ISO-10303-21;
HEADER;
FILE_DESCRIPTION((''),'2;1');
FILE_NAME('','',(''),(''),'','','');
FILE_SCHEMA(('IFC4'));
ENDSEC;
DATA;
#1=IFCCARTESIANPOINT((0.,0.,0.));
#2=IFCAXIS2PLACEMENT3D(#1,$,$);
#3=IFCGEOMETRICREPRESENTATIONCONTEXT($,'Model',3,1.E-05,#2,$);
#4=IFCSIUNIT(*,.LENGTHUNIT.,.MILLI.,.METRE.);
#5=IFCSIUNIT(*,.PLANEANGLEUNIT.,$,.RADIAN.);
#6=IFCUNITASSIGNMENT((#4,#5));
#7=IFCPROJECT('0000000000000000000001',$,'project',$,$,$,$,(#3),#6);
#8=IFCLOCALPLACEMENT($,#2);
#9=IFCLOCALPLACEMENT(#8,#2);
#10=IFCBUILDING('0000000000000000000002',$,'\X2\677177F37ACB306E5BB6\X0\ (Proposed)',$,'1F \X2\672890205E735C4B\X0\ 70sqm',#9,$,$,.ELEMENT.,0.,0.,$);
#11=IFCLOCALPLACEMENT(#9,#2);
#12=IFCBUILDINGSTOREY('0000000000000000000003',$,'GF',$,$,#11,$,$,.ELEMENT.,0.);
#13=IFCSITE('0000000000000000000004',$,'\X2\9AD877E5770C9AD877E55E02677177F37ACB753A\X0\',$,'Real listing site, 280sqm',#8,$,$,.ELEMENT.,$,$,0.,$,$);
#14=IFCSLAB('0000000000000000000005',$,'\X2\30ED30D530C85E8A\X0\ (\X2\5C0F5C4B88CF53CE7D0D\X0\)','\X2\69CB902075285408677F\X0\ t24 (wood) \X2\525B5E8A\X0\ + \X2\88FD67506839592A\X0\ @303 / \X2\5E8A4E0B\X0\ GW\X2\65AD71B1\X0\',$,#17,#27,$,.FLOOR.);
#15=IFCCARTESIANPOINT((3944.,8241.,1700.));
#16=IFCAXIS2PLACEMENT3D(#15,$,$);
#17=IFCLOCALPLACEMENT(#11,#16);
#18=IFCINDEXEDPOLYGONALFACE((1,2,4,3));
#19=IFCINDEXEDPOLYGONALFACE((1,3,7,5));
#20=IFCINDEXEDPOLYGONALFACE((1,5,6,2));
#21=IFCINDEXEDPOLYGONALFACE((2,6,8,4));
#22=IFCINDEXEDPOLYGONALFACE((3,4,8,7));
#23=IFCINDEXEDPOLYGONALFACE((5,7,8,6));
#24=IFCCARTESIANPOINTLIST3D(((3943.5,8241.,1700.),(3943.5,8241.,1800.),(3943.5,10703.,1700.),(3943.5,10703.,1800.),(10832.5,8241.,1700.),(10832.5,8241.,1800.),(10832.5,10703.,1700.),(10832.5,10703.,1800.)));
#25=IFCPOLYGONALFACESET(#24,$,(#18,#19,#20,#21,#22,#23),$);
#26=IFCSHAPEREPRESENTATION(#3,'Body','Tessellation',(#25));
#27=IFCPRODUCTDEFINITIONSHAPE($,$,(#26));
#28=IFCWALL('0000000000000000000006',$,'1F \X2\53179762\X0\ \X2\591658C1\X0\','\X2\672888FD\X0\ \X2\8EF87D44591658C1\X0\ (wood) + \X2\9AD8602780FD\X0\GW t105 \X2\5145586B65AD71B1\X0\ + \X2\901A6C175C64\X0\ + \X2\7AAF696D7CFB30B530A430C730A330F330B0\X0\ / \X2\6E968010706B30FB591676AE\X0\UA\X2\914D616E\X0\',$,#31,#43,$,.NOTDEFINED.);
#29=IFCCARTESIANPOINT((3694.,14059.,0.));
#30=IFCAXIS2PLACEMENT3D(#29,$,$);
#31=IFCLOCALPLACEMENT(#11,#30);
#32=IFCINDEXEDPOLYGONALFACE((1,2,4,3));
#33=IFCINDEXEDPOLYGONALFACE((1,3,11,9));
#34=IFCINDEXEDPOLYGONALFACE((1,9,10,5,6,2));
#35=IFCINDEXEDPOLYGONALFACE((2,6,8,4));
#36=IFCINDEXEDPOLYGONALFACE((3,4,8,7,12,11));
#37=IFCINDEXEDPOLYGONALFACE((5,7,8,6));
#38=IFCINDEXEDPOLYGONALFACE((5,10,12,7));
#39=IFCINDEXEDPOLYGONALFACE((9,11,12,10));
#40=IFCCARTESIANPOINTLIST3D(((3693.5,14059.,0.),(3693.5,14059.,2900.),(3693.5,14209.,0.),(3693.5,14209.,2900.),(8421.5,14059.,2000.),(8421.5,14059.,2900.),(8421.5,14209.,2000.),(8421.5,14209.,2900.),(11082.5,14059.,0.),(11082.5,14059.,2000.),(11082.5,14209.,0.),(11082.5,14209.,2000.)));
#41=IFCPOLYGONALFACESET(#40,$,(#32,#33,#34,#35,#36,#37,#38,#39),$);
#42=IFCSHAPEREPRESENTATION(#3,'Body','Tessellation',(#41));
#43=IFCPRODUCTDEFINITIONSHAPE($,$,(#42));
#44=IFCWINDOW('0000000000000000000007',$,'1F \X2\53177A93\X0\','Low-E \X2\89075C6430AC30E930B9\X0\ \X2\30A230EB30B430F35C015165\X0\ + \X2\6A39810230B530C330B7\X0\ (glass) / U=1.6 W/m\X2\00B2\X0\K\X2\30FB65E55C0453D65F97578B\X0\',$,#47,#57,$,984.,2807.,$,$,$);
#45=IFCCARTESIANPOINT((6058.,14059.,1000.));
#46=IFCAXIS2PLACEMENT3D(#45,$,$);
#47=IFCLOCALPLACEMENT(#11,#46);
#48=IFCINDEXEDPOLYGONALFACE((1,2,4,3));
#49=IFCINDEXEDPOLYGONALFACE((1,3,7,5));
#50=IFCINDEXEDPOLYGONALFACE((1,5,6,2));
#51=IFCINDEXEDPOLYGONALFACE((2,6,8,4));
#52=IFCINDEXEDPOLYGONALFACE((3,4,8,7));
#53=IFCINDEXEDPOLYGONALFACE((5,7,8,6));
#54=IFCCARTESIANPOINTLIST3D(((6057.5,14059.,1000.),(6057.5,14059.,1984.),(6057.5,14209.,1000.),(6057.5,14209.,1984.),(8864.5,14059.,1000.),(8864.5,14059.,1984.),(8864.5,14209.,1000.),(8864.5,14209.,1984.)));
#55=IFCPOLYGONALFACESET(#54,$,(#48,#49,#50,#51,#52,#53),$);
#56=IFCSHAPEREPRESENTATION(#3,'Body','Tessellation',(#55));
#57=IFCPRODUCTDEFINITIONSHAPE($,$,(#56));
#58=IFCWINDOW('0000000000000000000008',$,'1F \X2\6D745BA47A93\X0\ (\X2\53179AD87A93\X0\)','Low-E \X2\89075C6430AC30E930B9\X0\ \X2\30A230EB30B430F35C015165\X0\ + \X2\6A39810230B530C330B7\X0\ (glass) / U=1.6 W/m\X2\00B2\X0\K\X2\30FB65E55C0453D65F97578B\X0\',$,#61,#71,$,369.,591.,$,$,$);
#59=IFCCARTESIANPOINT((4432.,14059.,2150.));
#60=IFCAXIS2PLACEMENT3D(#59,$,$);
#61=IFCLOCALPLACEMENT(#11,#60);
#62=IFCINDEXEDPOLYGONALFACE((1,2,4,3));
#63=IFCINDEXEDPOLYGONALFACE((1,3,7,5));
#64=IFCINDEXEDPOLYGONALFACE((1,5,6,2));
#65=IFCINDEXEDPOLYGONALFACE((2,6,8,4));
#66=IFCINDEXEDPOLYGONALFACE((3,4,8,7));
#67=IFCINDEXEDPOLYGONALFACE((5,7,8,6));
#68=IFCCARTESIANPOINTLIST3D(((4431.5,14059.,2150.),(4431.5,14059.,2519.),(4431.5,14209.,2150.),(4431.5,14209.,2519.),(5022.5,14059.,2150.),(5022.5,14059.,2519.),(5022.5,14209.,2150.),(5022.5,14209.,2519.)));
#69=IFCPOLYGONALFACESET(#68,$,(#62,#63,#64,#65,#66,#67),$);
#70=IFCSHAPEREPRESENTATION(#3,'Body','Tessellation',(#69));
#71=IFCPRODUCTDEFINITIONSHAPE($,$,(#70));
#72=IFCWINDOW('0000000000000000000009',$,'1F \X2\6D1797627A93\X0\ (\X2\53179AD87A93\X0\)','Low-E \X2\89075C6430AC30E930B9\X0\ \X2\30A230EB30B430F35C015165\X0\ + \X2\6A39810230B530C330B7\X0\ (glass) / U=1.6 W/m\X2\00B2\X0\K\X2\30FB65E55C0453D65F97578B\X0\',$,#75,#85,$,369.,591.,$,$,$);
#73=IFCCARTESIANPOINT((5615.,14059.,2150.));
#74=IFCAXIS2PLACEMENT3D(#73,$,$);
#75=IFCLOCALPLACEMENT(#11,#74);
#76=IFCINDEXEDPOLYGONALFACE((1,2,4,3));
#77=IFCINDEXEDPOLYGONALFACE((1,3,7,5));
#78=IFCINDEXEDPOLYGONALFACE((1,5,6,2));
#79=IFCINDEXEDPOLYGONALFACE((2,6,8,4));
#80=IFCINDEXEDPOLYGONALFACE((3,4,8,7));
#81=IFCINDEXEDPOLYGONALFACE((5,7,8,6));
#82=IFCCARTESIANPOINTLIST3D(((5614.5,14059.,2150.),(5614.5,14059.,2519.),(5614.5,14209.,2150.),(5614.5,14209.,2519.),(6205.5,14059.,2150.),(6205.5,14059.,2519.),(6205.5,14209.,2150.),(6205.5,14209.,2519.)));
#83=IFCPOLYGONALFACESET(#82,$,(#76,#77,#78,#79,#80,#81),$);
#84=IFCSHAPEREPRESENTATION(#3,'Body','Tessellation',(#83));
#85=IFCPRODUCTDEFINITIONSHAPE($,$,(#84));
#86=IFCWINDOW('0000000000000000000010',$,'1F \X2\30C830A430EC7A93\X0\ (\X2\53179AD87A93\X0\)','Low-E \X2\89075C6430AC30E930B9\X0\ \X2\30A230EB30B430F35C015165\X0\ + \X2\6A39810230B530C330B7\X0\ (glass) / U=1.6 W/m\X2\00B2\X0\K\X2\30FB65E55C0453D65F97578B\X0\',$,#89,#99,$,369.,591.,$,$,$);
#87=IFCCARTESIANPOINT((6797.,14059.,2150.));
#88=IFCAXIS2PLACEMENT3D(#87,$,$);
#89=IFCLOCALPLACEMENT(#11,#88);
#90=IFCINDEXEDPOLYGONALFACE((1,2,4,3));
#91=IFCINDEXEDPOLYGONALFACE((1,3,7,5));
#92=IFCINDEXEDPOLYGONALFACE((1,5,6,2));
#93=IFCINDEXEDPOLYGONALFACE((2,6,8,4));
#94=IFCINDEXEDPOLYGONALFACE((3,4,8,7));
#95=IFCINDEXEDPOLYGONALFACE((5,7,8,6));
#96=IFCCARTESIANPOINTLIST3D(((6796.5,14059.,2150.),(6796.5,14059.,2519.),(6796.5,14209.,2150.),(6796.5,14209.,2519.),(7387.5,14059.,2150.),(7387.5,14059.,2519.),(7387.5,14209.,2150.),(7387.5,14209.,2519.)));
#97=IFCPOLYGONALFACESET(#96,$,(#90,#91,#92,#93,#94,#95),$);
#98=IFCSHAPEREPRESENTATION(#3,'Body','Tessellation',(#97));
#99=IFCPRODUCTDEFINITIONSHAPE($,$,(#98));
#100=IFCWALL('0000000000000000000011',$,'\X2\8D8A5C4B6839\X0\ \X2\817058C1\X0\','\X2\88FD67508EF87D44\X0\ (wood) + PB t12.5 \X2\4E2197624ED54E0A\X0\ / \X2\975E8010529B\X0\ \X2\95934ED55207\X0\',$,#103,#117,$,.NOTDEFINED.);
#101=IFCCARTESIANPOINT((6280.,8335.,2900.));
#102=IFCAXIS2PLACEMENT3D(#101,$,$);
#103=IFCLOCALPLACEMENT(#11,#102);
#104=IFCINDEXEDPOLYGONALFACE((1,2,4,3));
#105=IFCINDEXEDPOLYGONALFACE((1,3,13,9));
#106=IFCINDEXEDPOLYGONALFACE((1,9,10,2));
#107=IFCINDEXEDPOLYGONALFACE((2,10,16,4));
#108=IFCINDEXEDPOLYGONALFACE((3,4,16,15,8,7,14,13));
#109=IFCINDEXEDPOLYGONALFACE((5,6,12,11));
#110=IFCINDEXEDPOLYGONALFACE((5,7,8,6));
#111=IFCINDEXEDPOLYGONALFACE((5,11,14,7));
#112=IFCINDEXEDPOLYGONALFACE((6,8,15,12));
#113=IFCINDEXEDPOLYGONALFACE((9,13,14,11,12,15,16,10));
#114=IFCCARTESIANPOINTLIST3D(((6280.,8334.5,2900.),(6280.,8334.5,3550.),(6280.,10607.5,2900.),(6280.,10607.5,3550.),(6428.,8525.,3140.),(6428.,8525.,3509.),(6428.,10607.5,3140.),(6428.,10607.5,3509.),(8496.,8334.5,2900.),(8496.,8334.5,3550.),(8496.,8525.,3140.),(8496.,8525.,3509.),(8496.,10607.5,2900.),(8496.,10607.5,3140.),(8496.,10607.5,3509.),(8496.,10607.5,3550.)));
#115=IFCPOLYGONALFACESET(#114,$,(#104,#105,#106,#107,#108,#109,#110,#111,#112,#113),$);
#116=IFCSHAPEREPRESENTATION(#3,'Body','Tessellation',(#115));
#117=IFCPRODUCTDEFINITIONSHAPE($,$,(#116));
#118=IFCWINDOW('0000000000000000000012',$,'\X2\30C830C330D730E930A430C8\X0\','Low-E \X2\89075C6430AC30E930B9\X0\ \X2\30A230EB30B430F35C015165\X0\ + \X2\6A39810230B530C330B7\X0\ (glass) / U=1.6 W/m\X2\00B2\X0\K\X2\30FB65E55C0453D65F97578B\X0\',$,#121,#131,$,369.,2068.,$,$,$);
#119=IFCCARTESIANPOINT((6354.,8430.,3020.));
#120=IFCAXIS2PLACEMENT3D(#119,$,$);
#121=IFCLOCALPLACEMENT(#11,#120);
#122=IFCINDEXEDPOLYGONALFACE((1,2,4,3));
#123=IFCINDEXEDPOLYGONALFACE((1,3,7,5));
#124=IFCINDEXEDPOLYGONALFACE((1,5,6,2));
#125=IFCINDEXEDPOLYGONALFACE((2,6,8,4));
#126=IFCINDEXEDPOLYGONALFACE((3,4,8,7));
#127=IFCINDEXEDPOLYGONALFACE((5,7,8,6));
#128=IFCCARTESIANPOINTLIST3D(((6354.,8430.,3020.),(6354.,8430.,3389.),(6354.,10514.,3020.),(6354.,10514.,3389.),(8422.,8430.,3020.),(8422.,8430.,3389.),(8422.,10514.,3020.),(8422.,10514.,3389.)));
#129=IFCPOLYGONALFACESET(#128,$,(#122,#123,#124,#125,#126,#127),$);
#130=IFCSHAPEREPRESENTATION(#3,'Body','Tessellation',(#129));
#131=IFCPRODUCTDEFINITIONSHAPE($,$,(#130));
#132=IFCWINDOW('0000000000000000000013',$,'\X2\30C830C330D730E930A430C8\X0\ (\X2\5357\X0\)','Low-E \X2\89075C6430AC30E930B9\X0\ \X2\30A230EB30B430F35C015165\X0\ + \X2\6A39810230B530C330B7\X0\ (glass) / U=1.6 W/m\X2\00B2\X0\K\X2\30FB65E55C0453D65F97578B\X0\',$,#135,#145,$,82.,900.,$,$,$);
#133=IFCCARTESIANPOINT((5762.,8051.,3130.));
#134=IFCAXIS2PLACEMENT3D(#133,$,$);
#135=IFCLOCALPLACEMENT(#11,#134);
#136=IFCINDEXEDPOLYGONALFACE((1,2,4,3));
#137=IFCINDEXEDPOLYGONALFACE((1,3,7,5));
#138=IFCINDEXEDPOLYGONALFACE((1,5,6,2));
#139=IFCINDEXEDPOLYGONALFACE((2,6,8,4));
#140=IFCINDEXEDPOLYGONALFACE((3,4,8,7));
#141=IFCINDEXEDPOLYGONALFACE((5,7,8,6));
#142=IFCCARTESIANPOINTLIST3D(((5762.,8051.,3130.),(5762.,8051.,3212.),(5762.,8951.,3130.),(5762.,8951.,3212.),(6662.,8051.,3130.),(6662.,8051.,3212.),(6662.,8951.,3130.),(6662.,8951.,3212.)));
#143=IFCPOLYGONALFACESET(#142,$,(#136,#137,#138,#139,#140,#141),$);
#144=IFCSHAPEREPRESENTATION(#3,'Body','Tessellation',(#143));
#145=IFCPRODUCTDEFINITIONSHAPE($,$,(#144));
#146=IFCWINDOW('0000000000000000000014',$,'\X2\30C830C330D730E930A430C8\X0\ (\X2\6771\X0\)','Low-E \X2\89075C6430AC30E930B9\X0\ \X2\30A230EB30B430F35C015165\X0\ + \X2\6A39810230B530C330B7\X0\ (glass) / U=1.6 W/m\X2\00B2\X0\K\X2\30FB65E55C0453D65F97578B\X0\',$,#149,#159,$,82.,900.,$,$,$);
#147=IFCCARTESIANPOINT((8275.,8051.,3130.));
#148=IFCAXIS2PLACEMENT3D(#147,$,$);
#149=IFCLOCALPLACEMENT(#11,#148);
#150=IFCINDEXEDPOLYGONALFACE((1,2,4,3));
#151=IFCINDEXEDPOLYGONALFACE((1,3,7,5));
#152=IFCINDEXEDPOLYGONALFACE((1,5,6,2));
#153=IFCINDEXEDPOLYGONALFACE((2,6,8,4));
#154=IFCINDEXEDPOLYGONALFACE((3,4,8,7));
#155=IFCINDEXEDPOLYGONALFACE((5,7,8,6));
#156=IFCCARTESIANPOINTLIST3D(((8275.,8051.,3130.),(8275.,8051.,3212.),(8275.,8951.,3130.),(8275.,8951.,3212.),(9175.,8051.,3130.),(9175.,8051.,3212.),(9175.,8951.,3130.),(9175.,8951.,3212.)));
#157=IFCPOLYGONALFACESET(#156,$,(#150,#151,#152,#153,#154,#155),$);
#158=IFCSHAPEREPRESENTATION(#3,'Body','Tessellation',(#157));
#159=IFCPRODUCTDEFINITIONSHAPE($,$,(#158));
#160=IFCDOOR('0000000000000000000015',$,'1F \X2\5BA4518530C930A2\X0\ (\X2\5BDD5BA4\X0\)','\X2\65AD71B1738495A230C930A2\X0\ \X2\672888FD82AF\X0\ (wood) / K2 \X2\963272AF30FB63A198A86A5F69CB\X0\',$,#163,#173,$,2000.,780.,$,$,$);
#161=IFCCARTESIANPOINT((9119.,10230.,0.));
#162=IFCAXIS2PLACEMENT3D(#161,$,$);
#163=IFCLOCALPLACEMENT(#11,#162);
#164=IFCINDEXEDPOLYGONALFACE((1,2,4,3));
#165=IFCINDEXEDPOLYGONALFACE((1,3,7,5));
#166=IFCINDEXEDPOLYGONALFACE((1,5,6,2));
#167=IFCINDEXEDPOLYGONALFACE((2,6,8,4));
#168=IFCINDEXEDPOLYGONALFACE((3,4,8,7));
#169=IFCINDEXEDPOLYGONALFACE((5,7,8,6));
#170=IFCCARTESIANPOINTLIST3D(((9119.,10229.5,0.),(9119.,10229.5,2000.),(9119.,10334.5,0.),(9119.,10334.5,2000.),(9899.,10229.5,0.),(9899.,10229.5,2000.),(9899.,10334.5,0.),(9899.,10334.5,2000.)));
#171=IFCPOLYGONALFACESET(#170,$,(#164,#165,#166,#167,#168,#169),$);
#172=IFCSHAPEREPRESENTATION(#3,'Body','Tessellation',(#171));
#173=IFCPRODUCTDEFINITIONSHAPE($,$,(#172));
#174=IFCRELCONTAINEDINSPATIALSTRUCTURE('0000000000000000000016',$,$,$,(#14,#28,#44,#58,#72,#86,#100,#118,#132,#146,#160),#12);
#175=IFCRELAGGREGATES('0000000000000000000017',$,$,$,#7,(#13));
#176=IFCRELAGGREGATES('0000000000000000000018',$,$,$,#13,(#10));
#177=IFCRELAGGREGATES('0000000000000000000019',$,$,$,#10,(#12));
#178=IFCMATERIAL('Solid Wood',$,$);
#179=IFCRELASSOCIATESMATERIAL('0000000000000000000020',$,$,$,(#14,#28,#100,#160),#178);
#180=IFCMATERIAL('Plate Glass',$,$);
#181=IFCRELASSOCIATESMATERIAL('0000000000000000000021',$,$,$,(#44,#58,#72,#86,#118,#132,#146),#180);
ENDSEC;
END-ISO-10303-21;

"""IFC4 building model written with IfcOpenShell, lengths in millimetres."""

from ifc_helpers import new_model, si_unit, frame, frame_2d, origin, place, context, project, spatial, rectangle, extrude, material, element, fill, save


model = new_model("IFC4")

# Units and contexts
model_context = context("Model", 3, precision=1e-05, world=origin())
ifc_project = project(units=[si_unit("LENGTHUNIT", "METRE", prefix="MILLI"), si_unit("PLANEANGLEUNIT", "RADIAN")], contexts=[model_context])

# Site, building, storey
site_placement = place(None, origin())
site = spatial("IfcSite", under=ifc_project, at=site_placement, Name="高知県高知市東石立町", ObjectType="Real listing site, 280sqm", CompositionType="ELEMENT", RefElevation=0.0)
building_placement = place(site_placement, origin())
building = spatial("IfcBuilding", under=site, at=building_placement, Name="東石立の家 (Proposed)", ObjectType="1F 木造平屋 70sqm", CompositionType="ELEMENT", ElevationOfRefHeight=0.0, ElevationOfTerrain=0.0)
storey_placement = place(building_placement, origin())
storey = spatial("IfcBuildingStorey", under=building, at=storey_placement, Name="GF", CompositionType="ELEMENT", Elevation=0.0)

# Slab
ifc_material_1 = material(Name="Solid Wood")
slab_placement = place(storey_placement, frame((3944.0, 8241.0, 1700.0)))
element("IfcSlab", 1, at=slab_placement, inside=storey, material=ifc_material_1, Name="ロフト床 (小屋裏収納)", Description="構造用合板 t24 (wood) 剛床 + 製材根太 @303 / 床下 GW断熱", PredefinedType="FLOOR", context=model_context, shape_type="SweptSolid", body=[
    extrude(rectangle(XDim=6889.0, YDim=2462.0, at=frame_2d((3444.0, 1231.0))), frame((3944.0, 8241.0, 1700.0)), (0.0, 0.0, 1.0), 100.0),
])

# Wall, openings, windows
wall_1_placement = place(storey_placement, frame((3694.0, 14059.0, 0.0)))
wall_1 = element("IfcWall", 2, at=wall_1_placement, inside=storey, material=ifc_material_1, Name="1F 北面 外壁", Description="木製 軸組外壁 (wood) + 高性能GW t105 充填断熱 + 通気層 + 窯業系サイディング / 準耐火・外皮UA配慮", PredefinedType="NOTDEFINED", context=model_context, shape_type="SweptSolid", body=[
    extrude(rectangle(XDim=7389.0, YDim=150.0, at=frame_2d((3694.0, 75.0))), frame((3694.0, 14059.0, 0.0)), (0.0, 0.0, 1.0), 2900.0),
])
opening_1_placement = place(storey_placement, frame((6058.0, 14059.0, 1000.0)))
opening_1 = element("IfcOpeningElement", 3, at=opening_1_placement, cuts=wall_1, PredefinedType="NOTDEFINED", context=model_context, shape_type="SweptSolid", body=[
    extrude(rectangle(XDim=2807.0, YDim=150.0, at=frame_2d((1403.0, 75.0))), frame((6058.0, 14059.0, 1000.0)), (0.0, 0.0, 1.0), 984.0),
])
opening_2_placement = place(storey_placement, frame((4432.0, 14059.0, 2150.0)))
opening_2 = element("IfcOpeningElement", 4, at=opening_2_placement, cuts=wall_1, PredefinedType="NOTDEFINED", context=model_context, shape_type="SweptSolid", body=[
    extrude(rectangle(XDim=591.0, YDim=150.0, at=frame_2d((295.0, 75.0))), frame((4432.0, 14059.0, 2150.0)), (0.0, 0.0, 1.0), 369.0),
])
opening_3_placement = place(storey_placement, frame((5615.0, 14059.0, 2150.0)))
opening_3 = element("IfcOpeningElement", 5, at=opening_3_placement, cuts=wall_1, PredefinedType="NOTDEFINED", context=model_context, shape_type="SweptSolid", body=[
    extrude(rectangle(XDim=591.0, YDim=150.0, at=frame_2d((295.0, 75.0))), frame((5615.0, 14059.0, 2150.0)), (0.0, 0.0, 1.0), 369.0),
])
opening_4_placement = place(storey_placement, frame((6797.0, 14059.0, 2150.0)))
opening_4 = element("IfcOpeningElement", 6, at=opening_4_placement, cuts=wall_1, PredefinedType="NOTDEFINED", context=model_context, shape_type="SweptSolid", body=[
    extrude(rectangle(XDim=591.0, YDim=150.0, at=frame_2d((295.0, 75.0))), frame((6797.0, 14059.0, 2150.0)), (0.0, 0.0, 1.0), 369.0),
])
ifc_material_2 = material(Name="Plate Glass")
window_1_placement = place(storey_placement, frame((6058.0, 14059.0, 1000.0)))
window_1 = element("IfcWindow", 7, at=window_1_placement, inside=storey, material=ifc_material_2, Name="1F 北窓", Description="Low-E 複層ガラス アルゴン封入 + 樹脂サッシ (glass) / U=1.6 W/m²K・日射取得型", OverallHeight=984.0, OverallWidth=2807.0, context=model_context, shape_type="SweptSolid", body=[
    extrude(rectangle(XDim=2807.0, YDim=150.0, at=frame_2d((1403.0, 75.0))), frame((6058.0, 14059.0, 1000.0)), (0.0, 0.0, 1.0), 984.0),
])
fill(opening_1, window_1)
window_2_placement = place(storey_placement, frame((4432.0, 14059.0, 2150.0)))
window_2 = element("IfcWindow", 8, at=window_2_placement, inside=storey, material=ifc_material_2, Name="1F 浴室窓 (北高窓)", Description="Low-E 複層ガラス アルゴン封入 + 樹脂サッシ (glass) / U=1.6 W/m²K・日射取得型", OverallHeight=369.0, OverallWidth=591.0, context=model_context, shape_type="SweptSolid", body=[
    extrude(rectangle(XDim=591.0, YDim=150.0, at=frame_2d((295.0, 75.0))), frame((4432.0, 14059.0, 2150.0)), (0.0, 0.0, 1.0), 369.0),
])
fill(opening_2, window_2)
window_3_placement = place(storey_placement, frame((5615.0, 14059.0, 2150.0)))
window_3 = element("IfcWindow", 9, at=window_3_placement, inside=storey, material=ifc_material_2, Name="1F 洗面窓 (北高窓)", Description="Low-E 複層ガラス アルゴン封入 + 樹脂サッシ (glass) / U=1.6 W/m²K・日射取得型", OverallHeight=369.0, OverallWidth=591.0, context=model_context, shape_type="SweptSolid", body=[
    extrude(rectangle(XDim=591.0, YDim=150.0, at=frame_2d((295.0, 75.0))), frame((5615.0, 14059.0, 2150.0)), (0.0, 0.0, 1.0), 369.0),
])
fill(opening_3, window_3)
window_4_placement = place(storey_placement, frame((6797.0, 14059.0, 2150.0)))
window_4 = element("IfcWindow", 10, at=window_4_placement, inside=storey, material=ifc_material_2, Name="1F トイレ窓 (北高窓)", Description="Low-E 複層ガラス アルゴン封入 + 樹脂サッシ (glass) / U=1.6 W/m²K・日射取得型", OverallHeight=369.0, OverallWidth=591.0, context=model_context, shape_type="SweptSolid", body=[
    extrude(rectangle(XDim=591.0, YDim=150.0, at=frame_2d((295.0, 75.0))), frame((6797.0, 14059.0, 2150.0)), (0.0, 0.0, 1.0), 369.0),
])
fill(opening_4, window_4)

# Wall, openings, windows
wall_2_placement = place(storey_placement, frame((6280.0, 8335.0, 2900.0)))
wall_2 = element("IfcWall", 11, at=wall_2_placement, inside=storey, material=ifc_material_1, Name="越屋根 腰壁", Description="製材軸組 (wood) + PB t12.5 両面仕上 / 非耐力 間仕切", PredefinedType="NOTDEFINED", context=model_context, shape_type="SweptSolid", body=[
    extrude(rectangle(XDim=2216.0, YDim=2273.0, at=frame_2d((1108.0, 1136.0))), frame((6280.0, 8335.0, 2900.0)), (0.0, 0.0, 1.0), 650.0),
])
opening_5_placement = place(storey_placement, frame((6354.0, 8430.0, 3020.0)))
opening_5 = element("IfcOpeningElement", 12, at=opening_5_placement, cuts=wall_2, PredefinedType="NOTDEFINED", context=model_context, shape_type="SweptSolid", body=[
    extrude(rectangle(XDim=2068.0, YDim=2084.0, at=frame_2d((1034.0, 1042.0))), frame((6354.0, 8430.0, 3020.0)), (0.0, 0.0, 1.0), 369.0),
])
opening_6_placement = place(storey_placement, frame((5762.0, 8051.0, 3130.0)))
opening_6 = element("IfcOpeningElement", 13, at=opening_6_placement, cuts=wall_2, PredefinedType="NOTDEFINED", context=model_context, shape_type="SweptSolid", body=[
    extrude(rectangle(XDim=900.0, YDim=900.0, at=frame_2d((450.0, 450.0))), frame((5762.0, 8051.0, 3130.0)), (0.0, 0.0, 1.0), 82.0),
])
opening_7_placement = place(storey_placement, frame((8275.0, 8051.0, 3130.0)))
opening_7 = element("IfcOpeningElement", 14, at=opening_7_placement, cuts=wall_2, PredefinedType="NOTDEFINED", context=model_context, shape_type="SweptSolid", body=[
    extrude(rectangle(XDim=900.0, YDim=900.0, at=frame_2d((450.0, 450.0))), frame((8275.0, 8051.0, 3130.0)), (0.0, 0.0, 1.0), 82.0),
])
window_5_placement = place(storey_placement, frame((6354.0, 8430.0, 3020.0)))
window_5 = element("IfcWindow", 15, at=window_5_placement, inside=storey, material=ifc_material_2, Name="トップライト", Description="Low-E 複層ガラス アルゴン封入 + 樹脂サッシ (glass) / U=1.6 W/m²K・日射取得型", OverallHeight=369.0, OverallWidth=2068.0, context=model_context, shape_type="SweptSolid", body=[
    extrude(rectangle(XDim=2068.0, YDim=2084.0, at=frame_2d((1034.0, 1042.0))), frame((6354.0, 8430.0, 3020.0)), (0.0, 0.0, 1.0), 369.0),
])
fill(opening_5, window_5)
window_6_placement = place(storey_placement, frame((5762.0, 8051.0, 3130.0)))
window_6 = element("IfcWindow", 16, at=window_6_placement, inside=storey, material=ifc_material_2, Name="トップライト (南)", Description="Low-E 複層ガラス アルゴン封入 + 樹脂サッシ (glass) / U=1.6 W/m²K・日射取得型", OverallHeight=82.0, OverallWidth=900.0, context=model_context, shape_type="SweptSolid", body=[
    extrude(rectangle(XDim=900.0, YDim=900.0, at=frame_2d((450.0, 450.0))), frame((5762.0, 8051.0, 3130.0)), (0.0, 0.0, 1.0), 82.0),
])
fill(opening_6, window_6)
window_7_placement = place(storey_placement, frame((8275.0, 8051.0, 3130.0)))
window_7 = element("IfcWindow", 17, at=window_7_placement, inside=storey, material=ifc_material_2, Name="トップライト (東)", Description="Low-E 複層ガラス アルゴン封入 + 樹脂サッシ (glass) / U=1.6 W/m²K・日射取得型", OverallHeight=82.0, OverallWidth=900.0, context=model_context, shape_type="SweptSolid", body=[
    extrude(rectangle(XDim=900.0, YDim=900.0, at=frame_2d((450.0, 450.0))), frame((8275.0, 8051.0, 3130.0)), (0.0, 0.0, 1.0), 82.0),
])
fill(opening_7, window_7)

# Door
door_1_placement = place(storey_placement, frame((9119.0, 10230.0, 0.0)))
element("IfcDoor", 18, at=door_1_placement, inside=storey, material=ifc_material_1, Name="1F 室内ドア (寝室)", Description="断熱玄関ドア 木製芯 (wood) / K2 防犯・採風機構", OverallHeight=2000.0, OverallWidth=780.0, context=model_context, shape_type="SweptSolid", body=[
    extrude(rectangle(XDim=780.0, YDim=105.0, at=frame_2d((390.0, 52.0))), frame((9119.0, 10230.0, 0.0)), (0.0, 0.0, 1.0), 2000.0),
])

save(model, "model.ifc")
